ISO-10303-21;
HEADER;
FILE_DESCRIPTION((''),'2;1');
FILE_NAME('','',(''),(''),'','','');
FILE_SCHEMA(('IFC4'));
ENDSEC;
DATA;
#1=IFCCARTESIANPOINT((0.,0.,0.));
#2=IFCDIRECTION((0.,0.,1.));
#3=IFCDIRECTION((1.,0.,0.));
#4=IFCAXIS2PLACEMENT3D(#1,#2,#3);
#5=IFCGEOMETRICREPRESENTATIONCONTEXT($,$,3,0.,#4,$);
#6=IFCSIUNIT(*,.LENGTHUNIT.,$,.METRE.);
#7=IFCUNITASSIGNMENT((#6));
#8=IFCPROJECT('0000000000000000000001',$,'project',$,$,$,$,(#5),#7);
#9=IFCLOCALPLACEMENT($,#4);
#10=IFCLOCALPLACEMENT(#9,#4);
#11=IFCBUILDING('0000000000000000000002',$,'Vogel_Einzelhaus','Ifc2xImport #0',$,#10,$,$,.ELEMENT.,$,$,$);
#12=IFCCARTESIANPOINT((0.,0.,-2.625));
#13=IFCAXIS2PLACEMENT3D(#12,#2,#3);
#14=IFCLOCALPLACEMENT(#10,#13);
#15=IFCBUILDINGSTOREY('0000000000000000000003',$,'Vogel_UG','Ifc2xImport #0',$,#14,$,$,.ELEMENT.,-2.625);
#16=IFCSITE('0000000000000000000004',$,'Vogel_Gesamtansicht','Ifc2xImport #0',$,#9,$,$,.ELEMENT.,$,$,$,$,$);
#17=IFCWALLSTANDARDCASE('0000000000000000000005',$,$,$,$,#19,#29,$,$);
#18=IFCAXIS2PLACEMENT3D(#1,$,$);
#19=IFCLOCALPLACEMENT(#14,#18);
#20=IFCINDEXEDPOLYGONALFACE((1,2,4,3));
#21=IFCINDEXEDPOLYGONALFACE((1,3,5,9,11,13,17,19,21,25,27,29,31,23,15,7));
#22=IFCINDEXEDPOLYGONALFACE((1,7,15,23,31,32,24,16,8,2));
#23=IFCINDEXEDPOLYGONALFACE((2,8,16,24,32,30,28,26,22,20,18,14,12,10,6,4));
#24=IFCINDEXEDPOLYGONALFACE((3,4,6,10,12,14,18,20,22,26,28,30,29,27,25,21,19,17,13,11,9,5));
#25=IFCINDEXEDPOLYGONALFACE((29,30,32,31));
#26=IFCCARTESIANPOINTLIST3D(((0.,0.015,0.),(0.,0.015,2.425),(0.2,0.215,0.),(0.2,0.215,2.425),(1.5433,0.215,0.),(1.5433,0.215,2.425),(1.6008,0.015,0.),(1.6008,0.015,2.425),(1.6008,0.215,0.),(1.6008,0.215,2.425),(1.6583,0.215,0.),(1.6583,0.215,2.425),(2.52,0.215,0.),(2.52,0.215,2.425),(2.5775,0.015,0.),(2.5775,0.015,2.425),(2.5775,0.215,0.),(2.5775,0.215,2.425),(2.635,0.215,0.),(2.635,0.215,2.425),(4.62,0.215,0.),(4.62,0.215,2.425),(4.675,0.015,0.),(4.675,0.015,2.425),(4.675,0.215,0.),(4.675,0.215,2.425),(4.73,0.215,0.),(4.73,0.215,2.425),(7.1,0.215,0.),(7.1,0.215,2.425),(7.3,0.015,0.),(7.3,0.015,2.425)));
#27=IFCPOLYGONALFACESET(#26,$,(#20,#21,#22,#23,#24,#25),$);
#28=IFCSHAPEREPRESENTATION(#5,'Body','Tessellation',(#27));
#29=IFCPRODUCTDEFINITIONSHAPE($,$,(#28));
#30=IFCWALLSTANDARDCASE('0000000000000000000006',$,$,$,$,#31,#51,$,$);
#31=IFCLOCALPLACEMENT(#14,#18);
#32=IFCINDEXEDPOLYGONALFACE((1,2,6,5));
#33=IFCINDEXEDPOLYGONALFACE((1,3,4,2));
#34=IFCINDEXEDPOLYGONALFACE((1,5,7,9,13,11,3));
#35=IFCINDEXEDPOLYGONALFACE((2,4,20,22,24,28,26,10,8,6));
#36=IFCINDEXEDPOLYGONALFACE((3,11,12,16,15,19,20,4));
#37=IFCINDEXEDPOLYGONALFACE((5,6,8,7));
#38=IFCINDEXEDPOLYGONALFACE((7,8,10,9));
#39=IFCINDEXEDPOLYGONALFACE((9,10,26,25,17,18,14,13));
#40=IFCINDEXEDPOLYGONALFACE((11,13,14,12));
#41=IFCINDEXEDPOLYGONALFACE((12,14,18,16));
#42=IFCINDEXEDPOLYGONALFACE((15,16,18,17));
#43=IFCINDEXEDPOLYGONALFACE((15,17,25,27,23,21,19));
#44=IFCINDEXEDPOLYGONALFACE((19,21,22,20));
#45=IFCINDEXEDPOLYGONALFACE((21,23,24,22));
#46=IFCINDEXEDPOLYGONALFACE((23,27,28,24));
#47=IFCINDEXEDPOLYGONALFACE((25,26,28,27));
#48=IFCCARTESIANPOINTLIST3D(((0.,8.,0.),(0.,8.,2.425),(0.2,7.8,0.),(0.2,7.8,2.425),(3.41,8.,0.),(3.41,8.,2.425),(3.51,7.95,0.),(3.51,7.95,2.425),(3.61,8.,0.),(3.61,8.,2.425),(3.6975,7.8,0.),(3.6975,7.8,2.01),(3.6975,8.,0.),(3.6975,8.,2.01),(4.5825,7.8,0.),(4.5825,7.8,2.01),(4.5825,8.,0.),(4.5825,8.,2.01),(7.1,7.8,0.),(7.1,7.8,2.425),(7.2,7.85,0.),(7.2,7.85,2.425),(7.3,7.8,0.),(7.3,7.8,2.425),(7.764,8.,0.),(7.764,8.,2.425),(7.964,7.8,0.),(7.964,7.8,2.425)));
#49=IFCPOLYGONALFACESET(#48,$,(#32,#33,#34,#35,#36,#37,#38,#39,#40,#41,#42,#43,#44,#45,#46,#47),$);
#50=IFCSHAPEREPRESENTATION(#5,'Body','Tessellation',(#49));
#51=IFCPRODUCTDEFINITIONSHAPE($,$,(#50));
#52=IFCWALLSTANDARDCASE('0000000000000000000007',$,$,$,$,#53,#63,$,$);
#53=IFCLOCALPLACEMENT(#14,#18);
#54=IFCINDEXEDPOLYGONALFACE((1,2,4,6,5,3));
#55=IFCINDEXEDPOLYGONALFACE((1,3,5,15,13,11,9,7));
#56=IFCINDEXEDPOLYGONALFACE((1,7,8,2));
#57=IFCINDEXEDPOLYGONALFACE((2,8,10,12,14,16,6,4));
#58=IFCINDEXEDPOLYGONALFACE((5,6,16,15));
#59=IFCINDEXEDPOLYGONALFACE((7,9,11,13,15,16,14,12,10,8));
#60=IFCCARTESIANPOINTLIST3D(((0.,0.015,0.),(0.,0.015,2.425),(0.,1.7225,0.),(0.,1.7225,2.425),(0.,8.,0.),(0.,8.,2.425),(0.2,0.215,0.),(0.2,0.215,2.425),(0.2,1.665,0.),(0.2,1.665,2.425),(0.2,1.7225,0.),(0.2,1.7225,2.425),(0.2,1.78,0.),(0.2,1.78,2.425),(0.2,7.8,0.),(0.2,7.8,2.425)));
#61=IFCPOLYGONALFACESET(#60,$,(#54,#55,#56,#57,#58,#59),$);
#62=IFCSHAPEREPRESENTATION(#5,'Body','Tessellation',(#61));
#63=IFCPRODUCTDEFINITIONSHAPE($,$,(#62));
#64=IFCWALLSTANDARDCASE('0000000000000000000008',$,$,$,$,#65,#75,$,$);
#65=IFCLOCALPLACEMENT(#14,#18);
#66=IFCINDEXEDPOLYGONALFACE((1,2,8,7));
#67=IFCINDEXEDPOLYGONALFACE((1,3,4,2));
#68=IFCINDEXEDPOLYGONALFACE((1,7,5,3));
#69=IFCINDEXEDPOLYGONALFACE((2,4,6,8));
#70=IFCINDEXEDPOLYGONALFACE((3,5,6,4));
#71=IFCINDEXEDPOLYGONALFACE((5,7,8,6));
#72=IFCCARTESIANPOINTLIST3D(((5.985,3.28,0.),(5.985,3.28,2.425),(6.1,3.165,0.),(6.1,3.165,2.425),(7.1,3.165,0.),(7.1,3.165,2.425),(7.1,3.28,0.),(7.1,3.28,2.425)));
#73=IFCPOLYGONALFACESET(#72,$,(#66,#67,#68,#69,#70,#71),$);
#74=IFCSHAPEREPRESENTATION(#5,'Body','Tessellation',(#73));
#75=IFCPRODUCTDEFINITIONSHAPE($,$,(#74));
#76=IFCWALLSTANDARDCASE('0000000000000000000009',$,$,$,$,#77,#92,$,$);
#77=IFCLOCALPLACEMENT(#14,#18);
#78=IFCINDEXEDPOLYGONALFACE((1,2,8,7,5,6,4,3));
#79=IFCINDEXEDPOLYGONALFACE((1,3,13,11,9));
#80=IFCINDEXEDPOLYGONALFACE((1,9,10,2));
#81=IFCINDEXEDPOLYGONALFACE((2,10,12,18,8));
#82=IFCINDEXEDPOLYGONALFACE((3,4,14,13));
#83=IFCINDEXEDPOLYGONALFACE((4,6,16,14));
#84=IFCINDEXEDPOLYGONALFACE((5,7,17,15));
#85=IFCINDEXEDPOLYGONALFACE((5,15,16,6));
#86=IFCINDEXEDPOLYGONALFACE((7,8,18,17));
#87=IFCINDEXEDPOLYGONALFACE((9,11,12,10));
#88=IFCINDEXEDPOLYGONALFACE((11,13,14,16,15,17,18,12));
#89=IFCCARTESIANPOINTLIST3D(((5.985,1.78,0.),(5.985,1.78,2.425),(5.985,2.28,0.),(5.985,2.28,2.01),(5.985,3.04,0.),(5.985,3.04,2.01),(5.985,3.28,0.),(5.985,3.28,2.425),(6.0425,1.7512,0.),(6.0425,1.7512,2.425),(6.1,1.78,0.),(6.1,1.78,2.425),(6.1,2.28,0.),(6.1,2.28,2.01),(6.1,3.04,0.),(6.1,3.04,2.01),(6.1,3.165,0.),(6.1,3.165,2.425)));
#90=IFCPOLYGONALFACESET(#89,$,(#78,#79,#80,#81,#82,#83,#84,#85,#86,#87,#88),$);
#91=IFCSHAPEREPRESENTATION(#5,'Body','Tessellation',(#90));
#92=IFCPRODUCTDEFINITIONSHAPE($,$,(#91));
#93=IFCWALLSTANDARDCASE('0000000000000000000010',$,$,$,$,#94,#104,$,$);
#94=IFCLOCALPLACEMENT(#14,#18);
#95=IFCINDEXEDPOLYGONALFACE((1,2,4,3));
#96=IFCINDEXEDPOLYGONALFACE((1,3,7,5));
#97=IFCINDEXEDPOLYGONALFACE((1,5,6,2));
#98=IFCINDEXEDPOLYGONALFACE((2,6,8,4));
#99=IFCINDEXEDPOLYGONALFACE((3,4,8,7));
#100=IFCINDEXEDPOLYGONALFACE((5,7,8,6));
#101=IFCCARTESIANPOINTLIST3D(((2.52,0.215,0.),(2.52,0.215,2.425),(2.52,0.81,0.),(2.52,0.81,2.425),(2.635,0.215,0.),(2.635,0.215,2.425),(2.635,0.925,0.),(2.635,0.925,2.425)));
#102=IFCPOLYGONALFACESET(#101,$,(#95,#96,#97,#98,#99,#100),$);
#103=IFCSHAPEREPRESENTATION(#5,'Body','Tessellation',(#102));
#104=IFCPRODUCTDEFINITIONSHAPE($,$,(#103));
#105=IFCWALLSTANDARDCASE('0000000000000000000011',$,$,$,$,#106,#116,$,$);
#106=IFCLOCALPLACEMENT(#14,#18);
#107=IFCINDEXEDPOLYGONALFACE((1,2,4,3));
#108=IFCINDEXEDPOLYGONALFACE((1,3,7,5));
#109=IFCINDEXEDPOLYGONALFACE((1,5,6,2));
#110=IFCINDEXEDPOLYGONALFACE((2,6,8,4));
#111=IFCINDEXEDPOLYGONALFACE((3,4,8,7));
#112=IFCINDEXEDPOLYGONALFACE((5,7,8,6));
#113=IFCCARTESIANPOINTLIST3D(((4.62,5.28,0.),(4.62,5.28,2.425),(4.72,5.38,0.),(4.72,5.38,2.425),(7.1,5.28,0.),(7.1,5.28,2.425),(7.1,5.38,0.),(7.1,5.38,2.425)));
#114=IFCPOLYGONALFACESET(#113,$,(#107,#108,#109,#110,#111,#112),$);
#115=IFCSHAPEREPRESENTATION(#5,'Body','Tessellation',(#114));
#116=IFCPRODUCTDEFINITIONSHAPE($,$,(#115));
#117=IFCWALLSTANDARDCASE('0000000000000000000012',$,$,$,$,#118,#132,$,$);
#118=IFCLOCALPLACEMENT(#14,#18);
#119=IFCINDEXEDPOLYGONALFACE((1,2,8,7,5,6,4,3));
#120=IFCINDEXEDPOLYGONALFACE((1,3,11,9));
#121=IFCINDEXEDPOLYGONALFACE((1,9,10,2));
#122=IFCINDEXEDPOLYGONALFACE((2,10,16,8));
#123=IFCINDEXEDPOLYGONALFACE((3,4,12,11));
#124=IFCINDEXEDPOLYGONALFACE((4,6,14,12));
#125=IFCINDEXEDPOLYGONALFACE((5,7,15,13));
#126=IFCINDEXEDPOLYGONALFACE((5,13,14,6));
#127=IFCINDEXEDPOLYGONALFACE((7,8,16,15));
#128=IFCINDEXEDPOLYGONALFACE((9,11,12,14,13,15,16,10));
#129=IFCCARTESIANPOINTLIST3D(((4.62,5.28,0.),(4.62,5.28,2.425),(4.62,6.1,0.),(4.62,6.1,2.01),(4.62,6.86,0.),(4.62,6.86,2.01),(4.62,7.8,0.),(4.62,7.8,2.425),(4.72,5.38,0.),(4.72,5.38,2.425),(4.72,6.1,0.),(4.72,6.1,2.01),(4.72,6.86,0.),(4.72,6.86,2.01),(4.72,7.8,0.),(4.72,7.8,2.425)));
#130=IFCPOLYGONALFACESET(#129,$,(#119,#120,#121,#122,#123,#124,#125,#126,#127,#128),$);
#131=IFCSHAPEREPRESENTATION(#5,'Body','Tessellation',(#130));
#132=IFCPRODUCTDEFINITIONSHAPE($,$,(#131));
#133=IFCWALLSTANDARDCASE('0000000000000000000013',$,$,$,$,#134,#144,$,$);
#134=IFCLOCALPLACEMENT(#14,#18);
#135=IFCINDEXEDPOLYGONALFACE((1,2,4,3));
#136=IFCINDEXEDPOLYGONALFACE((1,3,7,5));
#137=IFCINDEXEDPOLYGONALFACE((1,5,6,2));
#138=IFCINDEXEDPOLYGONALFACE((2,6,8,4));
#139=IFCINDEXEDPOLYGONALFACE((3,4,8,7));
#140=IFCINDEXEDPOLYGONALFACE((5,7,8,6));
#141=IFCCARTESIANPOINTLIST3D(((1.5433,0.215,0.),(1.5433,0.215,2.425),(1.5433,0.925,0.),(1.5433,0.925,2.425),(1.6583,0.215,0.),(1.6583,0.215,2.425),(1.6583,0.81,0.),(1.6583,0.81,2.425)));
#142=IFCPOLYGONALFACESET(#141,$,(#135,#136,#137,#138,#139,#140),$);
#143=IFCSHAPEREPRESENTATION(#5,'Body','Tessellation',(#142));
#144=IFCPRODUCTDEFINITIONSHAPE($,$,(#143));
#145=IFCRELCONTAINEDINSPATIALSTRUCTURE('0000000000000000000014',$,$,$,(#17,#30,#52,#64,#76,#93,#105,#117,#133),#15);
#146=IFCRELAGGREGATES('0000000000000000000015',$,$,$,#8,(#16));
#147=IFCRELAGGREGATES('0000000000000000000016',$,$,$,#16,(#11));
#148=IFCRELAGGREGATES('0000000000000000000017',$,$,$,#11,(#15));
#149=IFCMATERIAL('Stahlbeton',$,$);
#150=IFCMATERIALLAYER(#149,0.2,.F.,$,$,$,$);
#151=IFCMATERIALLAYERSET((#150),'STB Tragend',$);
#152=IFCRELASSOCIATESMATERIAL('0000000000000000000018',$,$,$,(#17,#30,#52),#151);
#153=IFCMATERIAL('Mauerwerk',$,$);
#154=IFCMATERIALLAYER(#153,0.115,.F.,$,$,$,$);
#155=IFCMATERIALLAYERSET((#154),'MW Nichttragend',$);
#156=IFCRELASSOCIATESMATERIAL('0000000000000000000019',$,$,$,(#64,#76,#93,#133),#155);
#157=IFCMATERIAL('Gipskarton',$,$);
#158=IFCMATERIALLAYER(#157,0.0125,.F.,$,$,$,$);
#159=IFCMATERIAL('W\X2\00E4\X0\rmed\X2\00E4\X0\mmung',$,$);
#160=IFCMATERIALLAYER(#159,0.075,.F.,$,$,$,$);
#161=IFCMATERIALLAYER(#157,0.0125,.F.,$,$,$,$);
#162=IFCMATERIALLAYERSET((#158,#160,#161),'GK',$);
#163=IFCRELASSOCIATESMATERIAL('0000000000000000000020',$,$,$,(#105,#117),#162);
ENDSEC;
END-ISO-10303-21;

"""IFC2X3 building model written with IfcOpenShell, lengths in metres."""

from ifc_helpers import new_model, si_unit, frame, origin_with_axes, origin_2d_with_axis, place, context, project, spatial, polyline, rectangle, outline, extrude, shape, material, layer, layer_set, layer_usage, element, save


model = new_model("IFC2X3")

# Units and contexts
context_of_model = context(None, 3, precision=0.0, world=origin_with_axes())
ifc_project = project(units=[si_unit("LENGTHUNIT", "METRE")], contexts=[context_of_model])

# Site, building, storey
site_placement = place(None, origin_with_axes())
site = spatial("IfcSite", under=ifc_project, at=site_placement, Name="Vogel_Gesamtansicht", Description="Ifc2xImport #0", CompositionType="ELEMENT")
building_placement = place(site_placement, origin_with_axes())
building = spatial("IfcBuilding", under=site, at=building_placement, Name="Vogel_Einzelhaus", Description="Ifc2xImport #0", CompositionType="ELEMENT")
storey_placement = place(building_placement, frame((0.0, 0.0, -2.625), z_axis=(0.0, 0.0, 1.0), x_axis=(1.0, 0.0, 0.0)))
storey = spatial("IfcBuildingStorey", under=building, at=storey_placement, Name="Vogel_UG", Description="Ifc2xImport #0", CompositionType="ELEMENT", Elevation=-2.625)

# Wall
ifc_material_1 = material(Name="Stahlbeton")
ifc_layer_1 = layer(ifc_material_1, 0.2, ventilated=False)
ifc_layer_set_1 = layer_set([ifc_layer_1], Name="STB Tragend")
ifc_layer_usage_1 = layer_usage(ifc_layer_set_1, "AXIS2", "POSITIVE", -0.2)
wall_1_placement = place(storey_placement, frame((7.3, 0.015, 0.0), z_axis=(0.0, 0.0, 1.0), x_axis=(-1.0, 0.0, 0.0)))
element("IfcWallStandardCase", 1, at=wall_1_placement, inside=storey, material=ifc_layer_usage_1, context=context_of_model, shape_type="SweptSolid", body=[
    extrude(outline(polyline([(4.7225, -0.2), (4.78, -0.2), (5.6417, -0.2), (5.6992, -0.2), (5.7567, -0.2), (7.1, -0.2), (7.3, 0.0), (5.6992, 0.0), (4.7225, 0.0), (2.625, 0.0), (0.0, 0.0), (0.2, -0.2), (2.57, -0.2), (2.625, -0.2), (2.68, -0.2), (4.665, -0.2), (4.7225, -0.2)])), origin_with_axes(), (0.0, 0.0, 1.0), 2.425),
])

# Wall, opening
wall_2_placement = place(storey_placement, frame((0.0, 8.0, 0.0), z_axis=(0.0, 0.0, 1.0), x_axis=(1.0, 0.0, 0.0)))
wall_2 = element("IfcWallStandardCase", 2, at=wall_2_placement, inside=storey, material=ifc_layer_usage_1, context=context_of_model, shape_type="SweptSolid", body=[
    extrude(outline(polyline([(0.0, 0.0), (0.2, -0.2), (3.51, -0.2), (4.62, -0.2), (4.67, -0.2), (4.72, -0.2), (7.1, -0.2), (7.2, -0.15), (7.3, -0.2), (7.964, -0.2), (7.764, 0.0), (7.2, 0.0), (4.67, 0.0), (3.61, 0.0), (3.51, -0.05), (3.41, 0.0), (0.0, 0.0)])), origin_with_axes(), (0.0, 0.0, 1.0), 2.425),
])
opening_1_placement = place(wall_2_placement, frame((3.6975, 0.0, 0.0), z_axis=(1.0, 0.0, 0.0), x_axis=(0.0, 0.0, 1.0)))
element("IfcOpeningElement", 3, at=opening_1_placement, cuts=wall_2, shapes=[
    shape(context_of_model, None, "SweptSolid", [extrude(rectangle(XDim=2.01, YDim=0.885, at=origin_2d_with_axis()), frame((1.005, 0.0, 0.4425), z_axis=(0.0, 1.0, 0.0), x_axis=(1.0, 0.0, 0.0)), (0.0, 0.0, 1.0), 0.2)]),
])

# Walls
wall_3_placement = place(storey_placement, frame((0.0, 0.215, 0.0), z_axis=(0.0, 0.0, 1.0), x_axis=(0.0, 1.0, 0.0)))
element("IfcWallStandardCase", 4, at=wall_3_placement, inside=storey, material=ifc_layer_usage_1, context=context_of_model, shape_type="SweptSolid", body=[
    extrude(outline(polyline([(-0.2, 0.0), (0.0, -0.2), (1.45, -0.2), (1.5075, -0.2), (1.565, -0.2), (7.585, -0.2), (7.785, 0.0), (1.5075, 0.0), (-0.2, 0.0)])), origin_with_axes(), (0.0, 0.0, 1.0), 2.425),
])
ifc_material_2 = material(Name="Mauerwerk")
ifc_layer_2 = layer(ifc_material_2, 0.115, ventilated=False)
ifc_layer_set_2 = layer_set([ifc_layer_2], Name="MW Nichttragend")
ifc_layer_usage_2 = layer_usage(ifc_layer_set_2, "AXIS2", "POSITIVE", -0.115)
wall_4_placement = place(storey_placement, frame((5.985, 3.28, 0.0), z_axis=(0.0, 0.0, 1.0), x_axis=(1.0, 0.0, 0.0)))
element("IfcWallStandardCase", 5, at=wall_4_placement, inside=storey, material=ifc_layer_usage_2, context=context_of_model, shape_type="SweptSolid", body=[
    extrude(outline(polyline([(0.0, 0.0), (0.115, -0.115), (1.115, -0.115), (1.115, 0.0), (0.0, 0.0)])), origin_with_axes(), (0.0, 0.0, 1.0), 2.425),
])

# Wall, opening
wall_5_placement = place(storey_placement, frame((5.985, 1.78, 0.0), z_axis=(0.0, 0.0, 1.0), x_axis=(0.0, 1.0, 0.0)))
wall_5 = element("IfcWallStandardCase", 6, at=wall_5_placement, inside=storey, material=ifc_layer_usage_2, context=context_of_model, shape_type="SweptSolid", body=[
    extrude(outline(polyline([(0.0, 0.0), (-0.0288, -0.0575), (0.0, -0.115), (1.385, -0.115), (1.5, 0.0), (0.0, 0.0)])), origin_with_axes(), (0.0, 0.0, 1.0), 2.425),
])
opening_2_placement = place(wall_5_placement, frame((1.26, -0.115, 0.0), z_axis=(-1.0, 0.0, 0.0), x_axis=(0.0, 0.0, 1.0)))
element("IfcOpeningElement", 7, at=opening_2_placement, cuts=wall_5, shapes=[
    shape(context_of_model, None, "SweptSolid", [extrude(rectangle(XDim=2.01, YDim=0.76, at=origin_2d_with_axis()), frame((1.005, 0.0, 0.38), z_axis=(0.0, 1.0, 0.0), x_axis=(1.0, 0.0, 0.0)), (0.0, 0.0, 1.0), 0.115)]),
])

# Walls
ifc_layer_usage_3 = layer_usage(ifc_layer_set_2, "AXIS2", "POSITIVE", 0.0)
wall_6_placement = place(storey_placement, frame((2.52, 0.215, 0.0), z_axis=(0.0, 0.0, 1.0), x_axis=(0.0, 1.0, 0.0)))
element("IfcWallStandardCase", 8, at=wall_6_placement, inside=storey, material=ifc_layer_usage_2, context=context_of_model, shape_type="SweptSolid", body=[
    extrude(outline(polyline([(0.71, -0.115), (0.595, 0.0), (0.0, 0.0), (0.0, -0.115), (0.71, -0.115)])), origin_with_axes(), (0.0, 0.0, 1.0), 2.425),
])
ifc_material_3 = material(Name="Gipskarton")
ifc_layer_3 = layer(ifc_material_3, 0.0125, ventilated=False)
ifc_material_4 = material(Name="Wärmedämmung")
ifc_layer_4 = layer(ifc_material_4, 0.075, ventilated=False)
ifc_layer_5 = layer(ifc_material_3, 0.0125, ventilated=False)
ifc_layer_set_3 = layer_set([ifc_layer_3, ifc_layer_4, ifc_layer_5], Name="GK")
ifc_layer_usage_4 = layer_usage(ifc_layer_set_3, "AXIS2", "POSITIVE", 0.0)
wall_7_placement = place(storey_placement, frame((4.62, 5.28, 0.0), z_axis=(0.0, 0.0, 1.0), x_axis=(1.0, 0.0, 0.0)))
element("IfcWallStandardCase", 9, at=wall_7_placement, inside=storey, material=ifc_layer_usage_4, context=context_of_model, shape_type="SweptSolid", body=[
    extrude(outline(polyline([(0.0, 0.0), (2.48, 0.0), (2.48, 0.1), (0.1, 0.1), (0.0, 0.0)])), origin_with_axes(), (0.0, 0.0, 1.0), 2.425),
])

# Wall, opening
wall_8_placement = place(storey_placement, frame((4.62, 7.8, 0.0), z_axis=(0.0, 0.0, 1.0), x_axis=(0.0, -1.0, 0.0)))
wall_8 = element("IfcWallStandardCase", 10, at=wall_8_placement, inside=storey, material=ifc_layer_usage_4, context=context_of_model, shape_type="SweptSolid", body=[
    extrude(outline(polyline([(2.52, 0.0), (2.42, 0.1), (0.0, 0.1), (0.0, 0.0), (2.52, 0.0)])), origin_with_axes(), (0.0, 0.0, 1.0), 2.425),
])
opening_3_placement = place(wall_8_placement, frame((1.7, 0.0, 0.0), z_axis=(-1.0, 0.0, 0.0), x_axis=(0.0, 0.0, 1.0)))
element("IfcOpeningElement", 11, at=opening_3_placement, cuts=wall_8, shapes=[
    shape(context_of_model, None, "SweptSolid", [extrude(rectangle(XDim=2.01, YDim=0.76, at=origin_2d_with_axis()), frame((1.005, 0.0, 0.38), z_axis=(0.0, 1.0, 0.0), x_axis=(1.0, 0.0, 0.0)), (0.0, 0.0, 1.0), 0.1)]),
])

# Wall
wall_9_placement = place(storey_placement, frame((1.6583, 0.215, 0.0), z_axis=(0.0, 0.0, 1.0), x_axis=(0.0, 1.0, 0.0)))
element("IfcWallStandardCase", 12, at=wall_9_placement, inside=storey, material=ifc_layer_usage_3, context=context_of_model, shape_type="SweptSolid", body=[
    extrude(outline(polyline([(0.595, 0.0), (0.71, 0.115), (0.0, 0.115), (0.0, 0.0), (0.595, 0.0)])), origin_with_axes(), (0.0, 0.0, 1.0), 2.425),
])

save(model, "model.ifc")
